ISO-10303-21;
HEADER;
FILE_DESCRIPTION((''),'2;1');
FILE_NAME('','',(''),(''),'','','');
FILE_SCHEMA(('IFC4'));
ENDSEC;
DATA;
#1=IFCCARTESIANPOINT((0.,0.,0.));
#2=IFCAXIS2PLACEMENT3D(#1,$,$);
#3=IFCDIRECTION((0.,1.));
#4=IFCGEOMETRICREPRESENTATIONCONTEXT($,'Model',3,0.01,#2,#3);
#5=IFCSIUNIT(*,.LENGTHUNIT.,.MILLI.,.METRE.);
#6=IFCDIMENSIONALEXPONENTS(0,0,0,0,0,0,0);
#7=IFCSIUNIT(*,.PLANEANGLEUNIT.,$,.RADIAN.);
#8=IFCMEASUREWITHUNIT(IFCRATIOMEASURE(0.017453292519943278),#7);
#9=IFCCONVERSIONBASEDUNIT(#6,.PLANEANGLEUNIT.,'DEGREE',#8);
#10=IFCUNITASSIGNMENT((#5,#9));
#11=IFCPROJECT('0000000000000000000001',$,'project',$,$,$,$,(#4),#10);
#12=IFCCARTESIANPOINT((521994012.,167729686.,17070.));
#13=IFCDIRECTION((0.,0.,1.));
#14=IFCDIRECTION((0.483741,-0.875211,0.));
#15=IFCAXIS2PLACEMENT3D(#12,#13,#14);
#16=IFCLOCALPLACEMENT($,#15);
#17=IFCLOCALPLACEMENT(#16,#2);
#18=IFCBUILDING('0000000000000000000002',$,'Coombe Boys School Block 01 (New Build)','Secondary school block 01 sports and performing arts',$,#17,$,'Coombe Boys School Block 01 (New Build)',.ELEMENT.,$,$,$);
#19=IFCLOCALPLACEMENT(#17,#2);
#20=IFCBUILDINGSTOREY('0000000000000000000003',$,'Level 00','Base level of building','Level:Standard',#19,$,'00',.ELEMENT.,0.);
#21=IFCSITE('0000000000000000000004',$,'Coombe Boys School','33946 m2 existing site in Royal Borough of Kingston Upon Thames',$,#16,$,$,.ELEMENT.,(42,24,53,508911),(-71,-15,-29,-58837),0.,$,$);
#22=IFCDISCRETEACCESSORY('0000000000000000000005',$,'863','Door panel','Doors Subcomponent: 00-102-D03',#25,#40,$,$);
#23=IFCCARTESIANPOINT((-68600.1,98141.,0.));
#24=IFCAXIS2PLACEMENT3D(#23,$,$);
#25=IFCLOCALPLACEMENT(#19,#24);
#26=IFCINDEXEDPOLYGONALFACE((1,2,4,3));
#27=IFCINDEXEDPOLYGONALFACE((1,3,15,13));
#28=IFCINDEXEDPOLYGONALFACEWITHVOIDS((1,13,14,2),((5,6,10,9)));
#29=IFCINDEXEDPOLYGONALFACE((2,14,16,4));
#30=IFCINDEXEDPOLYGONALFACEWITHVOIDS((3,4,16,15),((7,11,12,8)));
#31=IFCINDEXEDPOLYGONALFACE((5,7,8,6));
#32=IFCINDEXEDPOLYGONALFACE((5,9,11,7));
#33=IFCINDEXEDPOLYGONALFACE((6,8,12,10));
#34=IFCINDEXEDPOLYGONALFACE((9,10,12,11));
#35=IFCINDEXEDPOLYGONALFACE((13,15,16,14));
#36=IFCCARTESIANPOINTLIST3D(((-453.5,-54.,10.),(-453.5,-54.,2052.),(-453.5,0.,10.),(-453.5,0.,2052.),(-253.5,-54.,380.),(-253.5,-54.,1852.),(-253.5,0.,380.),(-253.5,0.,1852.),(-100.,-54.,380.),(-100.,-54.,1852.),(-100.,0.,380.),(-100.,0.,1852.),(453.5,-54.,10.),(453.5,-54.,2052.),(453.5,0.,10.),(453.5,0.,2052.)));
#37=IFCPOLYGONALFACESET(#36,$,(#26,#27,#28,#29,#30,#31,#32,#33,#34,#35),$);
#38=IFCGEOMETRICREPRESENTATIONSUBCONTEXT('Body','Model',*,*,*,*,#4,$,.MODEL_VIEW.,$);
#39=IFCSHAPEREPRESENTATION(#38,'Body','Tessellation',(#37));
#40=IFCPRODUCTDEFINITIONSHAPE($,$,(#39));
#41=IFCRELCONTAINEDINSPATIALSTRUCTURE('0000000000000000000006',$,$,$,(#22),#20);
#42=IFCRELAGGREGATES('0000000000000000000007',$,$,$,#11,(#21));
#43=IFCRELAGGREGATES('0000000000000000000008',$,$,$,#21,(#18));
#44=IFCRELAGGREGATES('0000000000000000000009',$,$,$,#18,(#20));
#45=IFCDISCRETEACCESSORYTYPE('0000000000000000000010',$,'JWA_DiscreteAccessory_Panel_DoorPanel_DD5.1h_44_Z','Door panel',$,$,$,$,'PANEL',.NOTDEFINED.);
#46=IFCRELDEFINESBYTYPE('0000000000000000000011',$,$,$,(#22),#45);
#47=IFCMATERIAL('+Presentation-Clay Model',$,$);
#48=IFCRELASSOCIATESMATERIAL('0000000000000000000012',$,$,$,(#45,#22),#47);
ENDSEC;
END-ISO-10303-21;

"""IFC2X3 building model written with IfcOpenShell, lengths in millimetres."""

from ifc_helpers import new_model, entity, si_unit, converted_unit, direction, frame, origin, place, context, subcontext, project, spatial, polyline, outline, extrude, source, transform, mapped, material, type_object, type_shapes, element, save


model = new_model("IFC2X3")

# Units and contexts
model_context = context("Model", 3, precision=0.01, world=origin(), true_north=direction((0.0, 1.0)))
body_context = subcontext(model_context, "Body", "Model", "MODEL_VIEW")
ifc_project = project(units=[si_unit("LENGTHUNIT", "METRE", prefix="MILLI"), converted_unit("PLANEANGLEUNIT", "DEGREE", entity("IfcRatioMeasure", 0.017453292519943278), si_unit("PLANEANGLEUNIT", "RADIAN"), dimensions=[0, 0, 0, 0, 0, 0, 0])], contexts=[model_context])

# Site, building, storey
site_placement = place(None, frame((521994012.0, 167729686.0, 17070.0), z_axis=(0.0, 0.0, 1.0), x_axis=(0.483741, -0.875211, 0.0)))
site = spatial("IfcSite", under=ifc_project, at=site_placement, Name="Coombe Boys School", Description="33946 m2 existing site in Royal Borough of Kingston Upon Thames", CompositionType="ELEMENT", RefLatitude=(42, 24, 53, 508911), RefLongitude=(-71, -15, -29, -58837), RefElevation=0.0)
building_placement = place(site_placement, origin())
building = spatial("IfcBuilding", under=site, at=building_placement, Name="Coombe Boys School Block 01 (New Build)", Description="Secondary school block 01 sports and performing arts", LongName="Coombe Boys School Block 01 (New Build)", CompositionType="ELEMENT")
storey_placement = place(building_placement, origin())
storey = spatial("IfcBuildingStorey", under=building, at=storey_placement, Name="Level 00", Description="Base level of building", ObjectType="Level:Standard", LongName="00", CompositionType="ELEMENT", Elevation=0.0)

# Shared definitions
ifc_material_1 = material(Name="+Presentation-Clay Model")

# Discrete accessory
discrete_accessory_type_1 = type_object("IfcDiscreteAccessoryType", Name="JWA_DiscreteAccessory_Panel_DoorPanel_DD5.1h_44_Z", Description="Door panel", ElementType="PANEL", material=ifc_material_1)
shared_shape_1 = source(origin(), body_context, "Body", "SweptSolid", [
    extrude(outline(polyline([(-1021.0, -453.5), (1021.0, -453.5), (1021.0, 453.5), (-1021.0, 453.5), (-1021.0, -453.5)]), holes=[polyline([(-821.0, 100.0), (-821.0, 253.5), (651.0, 253.5), (651.0, 100.0), (-821.0, 100.0)])]), frame((0.0, -54.0, 1031.0), z_axis=(0.0, 1.0, 0.0), x_axis=(0.0, 0.0, -1.0)), (0.0, 0.0, 1.0), 54.0),
])
type_shapes(discrete_accessory_type_1, [shared_shape_1])
discrete_accessory_1_placement = place(storey_placement, frame((-68600.1, 98141.0, 0.0)))
element("IfcDiscreteAccessory", 1, at=discrete_accessory_1_placement, inside=storey, type_object=discrete_accessory_type_1, material=ifc_material_1, Name="863", Description="Door panel", ObjectType="Doors Subcomponent: 00-102-D03", context=body_context, shape_type="MappedRepresentation", body=[
    mapped(shared_shape_1, transform((0.0, 0.0, 0.0), scale=1.0)),
])

save(model, "model.ifc")
